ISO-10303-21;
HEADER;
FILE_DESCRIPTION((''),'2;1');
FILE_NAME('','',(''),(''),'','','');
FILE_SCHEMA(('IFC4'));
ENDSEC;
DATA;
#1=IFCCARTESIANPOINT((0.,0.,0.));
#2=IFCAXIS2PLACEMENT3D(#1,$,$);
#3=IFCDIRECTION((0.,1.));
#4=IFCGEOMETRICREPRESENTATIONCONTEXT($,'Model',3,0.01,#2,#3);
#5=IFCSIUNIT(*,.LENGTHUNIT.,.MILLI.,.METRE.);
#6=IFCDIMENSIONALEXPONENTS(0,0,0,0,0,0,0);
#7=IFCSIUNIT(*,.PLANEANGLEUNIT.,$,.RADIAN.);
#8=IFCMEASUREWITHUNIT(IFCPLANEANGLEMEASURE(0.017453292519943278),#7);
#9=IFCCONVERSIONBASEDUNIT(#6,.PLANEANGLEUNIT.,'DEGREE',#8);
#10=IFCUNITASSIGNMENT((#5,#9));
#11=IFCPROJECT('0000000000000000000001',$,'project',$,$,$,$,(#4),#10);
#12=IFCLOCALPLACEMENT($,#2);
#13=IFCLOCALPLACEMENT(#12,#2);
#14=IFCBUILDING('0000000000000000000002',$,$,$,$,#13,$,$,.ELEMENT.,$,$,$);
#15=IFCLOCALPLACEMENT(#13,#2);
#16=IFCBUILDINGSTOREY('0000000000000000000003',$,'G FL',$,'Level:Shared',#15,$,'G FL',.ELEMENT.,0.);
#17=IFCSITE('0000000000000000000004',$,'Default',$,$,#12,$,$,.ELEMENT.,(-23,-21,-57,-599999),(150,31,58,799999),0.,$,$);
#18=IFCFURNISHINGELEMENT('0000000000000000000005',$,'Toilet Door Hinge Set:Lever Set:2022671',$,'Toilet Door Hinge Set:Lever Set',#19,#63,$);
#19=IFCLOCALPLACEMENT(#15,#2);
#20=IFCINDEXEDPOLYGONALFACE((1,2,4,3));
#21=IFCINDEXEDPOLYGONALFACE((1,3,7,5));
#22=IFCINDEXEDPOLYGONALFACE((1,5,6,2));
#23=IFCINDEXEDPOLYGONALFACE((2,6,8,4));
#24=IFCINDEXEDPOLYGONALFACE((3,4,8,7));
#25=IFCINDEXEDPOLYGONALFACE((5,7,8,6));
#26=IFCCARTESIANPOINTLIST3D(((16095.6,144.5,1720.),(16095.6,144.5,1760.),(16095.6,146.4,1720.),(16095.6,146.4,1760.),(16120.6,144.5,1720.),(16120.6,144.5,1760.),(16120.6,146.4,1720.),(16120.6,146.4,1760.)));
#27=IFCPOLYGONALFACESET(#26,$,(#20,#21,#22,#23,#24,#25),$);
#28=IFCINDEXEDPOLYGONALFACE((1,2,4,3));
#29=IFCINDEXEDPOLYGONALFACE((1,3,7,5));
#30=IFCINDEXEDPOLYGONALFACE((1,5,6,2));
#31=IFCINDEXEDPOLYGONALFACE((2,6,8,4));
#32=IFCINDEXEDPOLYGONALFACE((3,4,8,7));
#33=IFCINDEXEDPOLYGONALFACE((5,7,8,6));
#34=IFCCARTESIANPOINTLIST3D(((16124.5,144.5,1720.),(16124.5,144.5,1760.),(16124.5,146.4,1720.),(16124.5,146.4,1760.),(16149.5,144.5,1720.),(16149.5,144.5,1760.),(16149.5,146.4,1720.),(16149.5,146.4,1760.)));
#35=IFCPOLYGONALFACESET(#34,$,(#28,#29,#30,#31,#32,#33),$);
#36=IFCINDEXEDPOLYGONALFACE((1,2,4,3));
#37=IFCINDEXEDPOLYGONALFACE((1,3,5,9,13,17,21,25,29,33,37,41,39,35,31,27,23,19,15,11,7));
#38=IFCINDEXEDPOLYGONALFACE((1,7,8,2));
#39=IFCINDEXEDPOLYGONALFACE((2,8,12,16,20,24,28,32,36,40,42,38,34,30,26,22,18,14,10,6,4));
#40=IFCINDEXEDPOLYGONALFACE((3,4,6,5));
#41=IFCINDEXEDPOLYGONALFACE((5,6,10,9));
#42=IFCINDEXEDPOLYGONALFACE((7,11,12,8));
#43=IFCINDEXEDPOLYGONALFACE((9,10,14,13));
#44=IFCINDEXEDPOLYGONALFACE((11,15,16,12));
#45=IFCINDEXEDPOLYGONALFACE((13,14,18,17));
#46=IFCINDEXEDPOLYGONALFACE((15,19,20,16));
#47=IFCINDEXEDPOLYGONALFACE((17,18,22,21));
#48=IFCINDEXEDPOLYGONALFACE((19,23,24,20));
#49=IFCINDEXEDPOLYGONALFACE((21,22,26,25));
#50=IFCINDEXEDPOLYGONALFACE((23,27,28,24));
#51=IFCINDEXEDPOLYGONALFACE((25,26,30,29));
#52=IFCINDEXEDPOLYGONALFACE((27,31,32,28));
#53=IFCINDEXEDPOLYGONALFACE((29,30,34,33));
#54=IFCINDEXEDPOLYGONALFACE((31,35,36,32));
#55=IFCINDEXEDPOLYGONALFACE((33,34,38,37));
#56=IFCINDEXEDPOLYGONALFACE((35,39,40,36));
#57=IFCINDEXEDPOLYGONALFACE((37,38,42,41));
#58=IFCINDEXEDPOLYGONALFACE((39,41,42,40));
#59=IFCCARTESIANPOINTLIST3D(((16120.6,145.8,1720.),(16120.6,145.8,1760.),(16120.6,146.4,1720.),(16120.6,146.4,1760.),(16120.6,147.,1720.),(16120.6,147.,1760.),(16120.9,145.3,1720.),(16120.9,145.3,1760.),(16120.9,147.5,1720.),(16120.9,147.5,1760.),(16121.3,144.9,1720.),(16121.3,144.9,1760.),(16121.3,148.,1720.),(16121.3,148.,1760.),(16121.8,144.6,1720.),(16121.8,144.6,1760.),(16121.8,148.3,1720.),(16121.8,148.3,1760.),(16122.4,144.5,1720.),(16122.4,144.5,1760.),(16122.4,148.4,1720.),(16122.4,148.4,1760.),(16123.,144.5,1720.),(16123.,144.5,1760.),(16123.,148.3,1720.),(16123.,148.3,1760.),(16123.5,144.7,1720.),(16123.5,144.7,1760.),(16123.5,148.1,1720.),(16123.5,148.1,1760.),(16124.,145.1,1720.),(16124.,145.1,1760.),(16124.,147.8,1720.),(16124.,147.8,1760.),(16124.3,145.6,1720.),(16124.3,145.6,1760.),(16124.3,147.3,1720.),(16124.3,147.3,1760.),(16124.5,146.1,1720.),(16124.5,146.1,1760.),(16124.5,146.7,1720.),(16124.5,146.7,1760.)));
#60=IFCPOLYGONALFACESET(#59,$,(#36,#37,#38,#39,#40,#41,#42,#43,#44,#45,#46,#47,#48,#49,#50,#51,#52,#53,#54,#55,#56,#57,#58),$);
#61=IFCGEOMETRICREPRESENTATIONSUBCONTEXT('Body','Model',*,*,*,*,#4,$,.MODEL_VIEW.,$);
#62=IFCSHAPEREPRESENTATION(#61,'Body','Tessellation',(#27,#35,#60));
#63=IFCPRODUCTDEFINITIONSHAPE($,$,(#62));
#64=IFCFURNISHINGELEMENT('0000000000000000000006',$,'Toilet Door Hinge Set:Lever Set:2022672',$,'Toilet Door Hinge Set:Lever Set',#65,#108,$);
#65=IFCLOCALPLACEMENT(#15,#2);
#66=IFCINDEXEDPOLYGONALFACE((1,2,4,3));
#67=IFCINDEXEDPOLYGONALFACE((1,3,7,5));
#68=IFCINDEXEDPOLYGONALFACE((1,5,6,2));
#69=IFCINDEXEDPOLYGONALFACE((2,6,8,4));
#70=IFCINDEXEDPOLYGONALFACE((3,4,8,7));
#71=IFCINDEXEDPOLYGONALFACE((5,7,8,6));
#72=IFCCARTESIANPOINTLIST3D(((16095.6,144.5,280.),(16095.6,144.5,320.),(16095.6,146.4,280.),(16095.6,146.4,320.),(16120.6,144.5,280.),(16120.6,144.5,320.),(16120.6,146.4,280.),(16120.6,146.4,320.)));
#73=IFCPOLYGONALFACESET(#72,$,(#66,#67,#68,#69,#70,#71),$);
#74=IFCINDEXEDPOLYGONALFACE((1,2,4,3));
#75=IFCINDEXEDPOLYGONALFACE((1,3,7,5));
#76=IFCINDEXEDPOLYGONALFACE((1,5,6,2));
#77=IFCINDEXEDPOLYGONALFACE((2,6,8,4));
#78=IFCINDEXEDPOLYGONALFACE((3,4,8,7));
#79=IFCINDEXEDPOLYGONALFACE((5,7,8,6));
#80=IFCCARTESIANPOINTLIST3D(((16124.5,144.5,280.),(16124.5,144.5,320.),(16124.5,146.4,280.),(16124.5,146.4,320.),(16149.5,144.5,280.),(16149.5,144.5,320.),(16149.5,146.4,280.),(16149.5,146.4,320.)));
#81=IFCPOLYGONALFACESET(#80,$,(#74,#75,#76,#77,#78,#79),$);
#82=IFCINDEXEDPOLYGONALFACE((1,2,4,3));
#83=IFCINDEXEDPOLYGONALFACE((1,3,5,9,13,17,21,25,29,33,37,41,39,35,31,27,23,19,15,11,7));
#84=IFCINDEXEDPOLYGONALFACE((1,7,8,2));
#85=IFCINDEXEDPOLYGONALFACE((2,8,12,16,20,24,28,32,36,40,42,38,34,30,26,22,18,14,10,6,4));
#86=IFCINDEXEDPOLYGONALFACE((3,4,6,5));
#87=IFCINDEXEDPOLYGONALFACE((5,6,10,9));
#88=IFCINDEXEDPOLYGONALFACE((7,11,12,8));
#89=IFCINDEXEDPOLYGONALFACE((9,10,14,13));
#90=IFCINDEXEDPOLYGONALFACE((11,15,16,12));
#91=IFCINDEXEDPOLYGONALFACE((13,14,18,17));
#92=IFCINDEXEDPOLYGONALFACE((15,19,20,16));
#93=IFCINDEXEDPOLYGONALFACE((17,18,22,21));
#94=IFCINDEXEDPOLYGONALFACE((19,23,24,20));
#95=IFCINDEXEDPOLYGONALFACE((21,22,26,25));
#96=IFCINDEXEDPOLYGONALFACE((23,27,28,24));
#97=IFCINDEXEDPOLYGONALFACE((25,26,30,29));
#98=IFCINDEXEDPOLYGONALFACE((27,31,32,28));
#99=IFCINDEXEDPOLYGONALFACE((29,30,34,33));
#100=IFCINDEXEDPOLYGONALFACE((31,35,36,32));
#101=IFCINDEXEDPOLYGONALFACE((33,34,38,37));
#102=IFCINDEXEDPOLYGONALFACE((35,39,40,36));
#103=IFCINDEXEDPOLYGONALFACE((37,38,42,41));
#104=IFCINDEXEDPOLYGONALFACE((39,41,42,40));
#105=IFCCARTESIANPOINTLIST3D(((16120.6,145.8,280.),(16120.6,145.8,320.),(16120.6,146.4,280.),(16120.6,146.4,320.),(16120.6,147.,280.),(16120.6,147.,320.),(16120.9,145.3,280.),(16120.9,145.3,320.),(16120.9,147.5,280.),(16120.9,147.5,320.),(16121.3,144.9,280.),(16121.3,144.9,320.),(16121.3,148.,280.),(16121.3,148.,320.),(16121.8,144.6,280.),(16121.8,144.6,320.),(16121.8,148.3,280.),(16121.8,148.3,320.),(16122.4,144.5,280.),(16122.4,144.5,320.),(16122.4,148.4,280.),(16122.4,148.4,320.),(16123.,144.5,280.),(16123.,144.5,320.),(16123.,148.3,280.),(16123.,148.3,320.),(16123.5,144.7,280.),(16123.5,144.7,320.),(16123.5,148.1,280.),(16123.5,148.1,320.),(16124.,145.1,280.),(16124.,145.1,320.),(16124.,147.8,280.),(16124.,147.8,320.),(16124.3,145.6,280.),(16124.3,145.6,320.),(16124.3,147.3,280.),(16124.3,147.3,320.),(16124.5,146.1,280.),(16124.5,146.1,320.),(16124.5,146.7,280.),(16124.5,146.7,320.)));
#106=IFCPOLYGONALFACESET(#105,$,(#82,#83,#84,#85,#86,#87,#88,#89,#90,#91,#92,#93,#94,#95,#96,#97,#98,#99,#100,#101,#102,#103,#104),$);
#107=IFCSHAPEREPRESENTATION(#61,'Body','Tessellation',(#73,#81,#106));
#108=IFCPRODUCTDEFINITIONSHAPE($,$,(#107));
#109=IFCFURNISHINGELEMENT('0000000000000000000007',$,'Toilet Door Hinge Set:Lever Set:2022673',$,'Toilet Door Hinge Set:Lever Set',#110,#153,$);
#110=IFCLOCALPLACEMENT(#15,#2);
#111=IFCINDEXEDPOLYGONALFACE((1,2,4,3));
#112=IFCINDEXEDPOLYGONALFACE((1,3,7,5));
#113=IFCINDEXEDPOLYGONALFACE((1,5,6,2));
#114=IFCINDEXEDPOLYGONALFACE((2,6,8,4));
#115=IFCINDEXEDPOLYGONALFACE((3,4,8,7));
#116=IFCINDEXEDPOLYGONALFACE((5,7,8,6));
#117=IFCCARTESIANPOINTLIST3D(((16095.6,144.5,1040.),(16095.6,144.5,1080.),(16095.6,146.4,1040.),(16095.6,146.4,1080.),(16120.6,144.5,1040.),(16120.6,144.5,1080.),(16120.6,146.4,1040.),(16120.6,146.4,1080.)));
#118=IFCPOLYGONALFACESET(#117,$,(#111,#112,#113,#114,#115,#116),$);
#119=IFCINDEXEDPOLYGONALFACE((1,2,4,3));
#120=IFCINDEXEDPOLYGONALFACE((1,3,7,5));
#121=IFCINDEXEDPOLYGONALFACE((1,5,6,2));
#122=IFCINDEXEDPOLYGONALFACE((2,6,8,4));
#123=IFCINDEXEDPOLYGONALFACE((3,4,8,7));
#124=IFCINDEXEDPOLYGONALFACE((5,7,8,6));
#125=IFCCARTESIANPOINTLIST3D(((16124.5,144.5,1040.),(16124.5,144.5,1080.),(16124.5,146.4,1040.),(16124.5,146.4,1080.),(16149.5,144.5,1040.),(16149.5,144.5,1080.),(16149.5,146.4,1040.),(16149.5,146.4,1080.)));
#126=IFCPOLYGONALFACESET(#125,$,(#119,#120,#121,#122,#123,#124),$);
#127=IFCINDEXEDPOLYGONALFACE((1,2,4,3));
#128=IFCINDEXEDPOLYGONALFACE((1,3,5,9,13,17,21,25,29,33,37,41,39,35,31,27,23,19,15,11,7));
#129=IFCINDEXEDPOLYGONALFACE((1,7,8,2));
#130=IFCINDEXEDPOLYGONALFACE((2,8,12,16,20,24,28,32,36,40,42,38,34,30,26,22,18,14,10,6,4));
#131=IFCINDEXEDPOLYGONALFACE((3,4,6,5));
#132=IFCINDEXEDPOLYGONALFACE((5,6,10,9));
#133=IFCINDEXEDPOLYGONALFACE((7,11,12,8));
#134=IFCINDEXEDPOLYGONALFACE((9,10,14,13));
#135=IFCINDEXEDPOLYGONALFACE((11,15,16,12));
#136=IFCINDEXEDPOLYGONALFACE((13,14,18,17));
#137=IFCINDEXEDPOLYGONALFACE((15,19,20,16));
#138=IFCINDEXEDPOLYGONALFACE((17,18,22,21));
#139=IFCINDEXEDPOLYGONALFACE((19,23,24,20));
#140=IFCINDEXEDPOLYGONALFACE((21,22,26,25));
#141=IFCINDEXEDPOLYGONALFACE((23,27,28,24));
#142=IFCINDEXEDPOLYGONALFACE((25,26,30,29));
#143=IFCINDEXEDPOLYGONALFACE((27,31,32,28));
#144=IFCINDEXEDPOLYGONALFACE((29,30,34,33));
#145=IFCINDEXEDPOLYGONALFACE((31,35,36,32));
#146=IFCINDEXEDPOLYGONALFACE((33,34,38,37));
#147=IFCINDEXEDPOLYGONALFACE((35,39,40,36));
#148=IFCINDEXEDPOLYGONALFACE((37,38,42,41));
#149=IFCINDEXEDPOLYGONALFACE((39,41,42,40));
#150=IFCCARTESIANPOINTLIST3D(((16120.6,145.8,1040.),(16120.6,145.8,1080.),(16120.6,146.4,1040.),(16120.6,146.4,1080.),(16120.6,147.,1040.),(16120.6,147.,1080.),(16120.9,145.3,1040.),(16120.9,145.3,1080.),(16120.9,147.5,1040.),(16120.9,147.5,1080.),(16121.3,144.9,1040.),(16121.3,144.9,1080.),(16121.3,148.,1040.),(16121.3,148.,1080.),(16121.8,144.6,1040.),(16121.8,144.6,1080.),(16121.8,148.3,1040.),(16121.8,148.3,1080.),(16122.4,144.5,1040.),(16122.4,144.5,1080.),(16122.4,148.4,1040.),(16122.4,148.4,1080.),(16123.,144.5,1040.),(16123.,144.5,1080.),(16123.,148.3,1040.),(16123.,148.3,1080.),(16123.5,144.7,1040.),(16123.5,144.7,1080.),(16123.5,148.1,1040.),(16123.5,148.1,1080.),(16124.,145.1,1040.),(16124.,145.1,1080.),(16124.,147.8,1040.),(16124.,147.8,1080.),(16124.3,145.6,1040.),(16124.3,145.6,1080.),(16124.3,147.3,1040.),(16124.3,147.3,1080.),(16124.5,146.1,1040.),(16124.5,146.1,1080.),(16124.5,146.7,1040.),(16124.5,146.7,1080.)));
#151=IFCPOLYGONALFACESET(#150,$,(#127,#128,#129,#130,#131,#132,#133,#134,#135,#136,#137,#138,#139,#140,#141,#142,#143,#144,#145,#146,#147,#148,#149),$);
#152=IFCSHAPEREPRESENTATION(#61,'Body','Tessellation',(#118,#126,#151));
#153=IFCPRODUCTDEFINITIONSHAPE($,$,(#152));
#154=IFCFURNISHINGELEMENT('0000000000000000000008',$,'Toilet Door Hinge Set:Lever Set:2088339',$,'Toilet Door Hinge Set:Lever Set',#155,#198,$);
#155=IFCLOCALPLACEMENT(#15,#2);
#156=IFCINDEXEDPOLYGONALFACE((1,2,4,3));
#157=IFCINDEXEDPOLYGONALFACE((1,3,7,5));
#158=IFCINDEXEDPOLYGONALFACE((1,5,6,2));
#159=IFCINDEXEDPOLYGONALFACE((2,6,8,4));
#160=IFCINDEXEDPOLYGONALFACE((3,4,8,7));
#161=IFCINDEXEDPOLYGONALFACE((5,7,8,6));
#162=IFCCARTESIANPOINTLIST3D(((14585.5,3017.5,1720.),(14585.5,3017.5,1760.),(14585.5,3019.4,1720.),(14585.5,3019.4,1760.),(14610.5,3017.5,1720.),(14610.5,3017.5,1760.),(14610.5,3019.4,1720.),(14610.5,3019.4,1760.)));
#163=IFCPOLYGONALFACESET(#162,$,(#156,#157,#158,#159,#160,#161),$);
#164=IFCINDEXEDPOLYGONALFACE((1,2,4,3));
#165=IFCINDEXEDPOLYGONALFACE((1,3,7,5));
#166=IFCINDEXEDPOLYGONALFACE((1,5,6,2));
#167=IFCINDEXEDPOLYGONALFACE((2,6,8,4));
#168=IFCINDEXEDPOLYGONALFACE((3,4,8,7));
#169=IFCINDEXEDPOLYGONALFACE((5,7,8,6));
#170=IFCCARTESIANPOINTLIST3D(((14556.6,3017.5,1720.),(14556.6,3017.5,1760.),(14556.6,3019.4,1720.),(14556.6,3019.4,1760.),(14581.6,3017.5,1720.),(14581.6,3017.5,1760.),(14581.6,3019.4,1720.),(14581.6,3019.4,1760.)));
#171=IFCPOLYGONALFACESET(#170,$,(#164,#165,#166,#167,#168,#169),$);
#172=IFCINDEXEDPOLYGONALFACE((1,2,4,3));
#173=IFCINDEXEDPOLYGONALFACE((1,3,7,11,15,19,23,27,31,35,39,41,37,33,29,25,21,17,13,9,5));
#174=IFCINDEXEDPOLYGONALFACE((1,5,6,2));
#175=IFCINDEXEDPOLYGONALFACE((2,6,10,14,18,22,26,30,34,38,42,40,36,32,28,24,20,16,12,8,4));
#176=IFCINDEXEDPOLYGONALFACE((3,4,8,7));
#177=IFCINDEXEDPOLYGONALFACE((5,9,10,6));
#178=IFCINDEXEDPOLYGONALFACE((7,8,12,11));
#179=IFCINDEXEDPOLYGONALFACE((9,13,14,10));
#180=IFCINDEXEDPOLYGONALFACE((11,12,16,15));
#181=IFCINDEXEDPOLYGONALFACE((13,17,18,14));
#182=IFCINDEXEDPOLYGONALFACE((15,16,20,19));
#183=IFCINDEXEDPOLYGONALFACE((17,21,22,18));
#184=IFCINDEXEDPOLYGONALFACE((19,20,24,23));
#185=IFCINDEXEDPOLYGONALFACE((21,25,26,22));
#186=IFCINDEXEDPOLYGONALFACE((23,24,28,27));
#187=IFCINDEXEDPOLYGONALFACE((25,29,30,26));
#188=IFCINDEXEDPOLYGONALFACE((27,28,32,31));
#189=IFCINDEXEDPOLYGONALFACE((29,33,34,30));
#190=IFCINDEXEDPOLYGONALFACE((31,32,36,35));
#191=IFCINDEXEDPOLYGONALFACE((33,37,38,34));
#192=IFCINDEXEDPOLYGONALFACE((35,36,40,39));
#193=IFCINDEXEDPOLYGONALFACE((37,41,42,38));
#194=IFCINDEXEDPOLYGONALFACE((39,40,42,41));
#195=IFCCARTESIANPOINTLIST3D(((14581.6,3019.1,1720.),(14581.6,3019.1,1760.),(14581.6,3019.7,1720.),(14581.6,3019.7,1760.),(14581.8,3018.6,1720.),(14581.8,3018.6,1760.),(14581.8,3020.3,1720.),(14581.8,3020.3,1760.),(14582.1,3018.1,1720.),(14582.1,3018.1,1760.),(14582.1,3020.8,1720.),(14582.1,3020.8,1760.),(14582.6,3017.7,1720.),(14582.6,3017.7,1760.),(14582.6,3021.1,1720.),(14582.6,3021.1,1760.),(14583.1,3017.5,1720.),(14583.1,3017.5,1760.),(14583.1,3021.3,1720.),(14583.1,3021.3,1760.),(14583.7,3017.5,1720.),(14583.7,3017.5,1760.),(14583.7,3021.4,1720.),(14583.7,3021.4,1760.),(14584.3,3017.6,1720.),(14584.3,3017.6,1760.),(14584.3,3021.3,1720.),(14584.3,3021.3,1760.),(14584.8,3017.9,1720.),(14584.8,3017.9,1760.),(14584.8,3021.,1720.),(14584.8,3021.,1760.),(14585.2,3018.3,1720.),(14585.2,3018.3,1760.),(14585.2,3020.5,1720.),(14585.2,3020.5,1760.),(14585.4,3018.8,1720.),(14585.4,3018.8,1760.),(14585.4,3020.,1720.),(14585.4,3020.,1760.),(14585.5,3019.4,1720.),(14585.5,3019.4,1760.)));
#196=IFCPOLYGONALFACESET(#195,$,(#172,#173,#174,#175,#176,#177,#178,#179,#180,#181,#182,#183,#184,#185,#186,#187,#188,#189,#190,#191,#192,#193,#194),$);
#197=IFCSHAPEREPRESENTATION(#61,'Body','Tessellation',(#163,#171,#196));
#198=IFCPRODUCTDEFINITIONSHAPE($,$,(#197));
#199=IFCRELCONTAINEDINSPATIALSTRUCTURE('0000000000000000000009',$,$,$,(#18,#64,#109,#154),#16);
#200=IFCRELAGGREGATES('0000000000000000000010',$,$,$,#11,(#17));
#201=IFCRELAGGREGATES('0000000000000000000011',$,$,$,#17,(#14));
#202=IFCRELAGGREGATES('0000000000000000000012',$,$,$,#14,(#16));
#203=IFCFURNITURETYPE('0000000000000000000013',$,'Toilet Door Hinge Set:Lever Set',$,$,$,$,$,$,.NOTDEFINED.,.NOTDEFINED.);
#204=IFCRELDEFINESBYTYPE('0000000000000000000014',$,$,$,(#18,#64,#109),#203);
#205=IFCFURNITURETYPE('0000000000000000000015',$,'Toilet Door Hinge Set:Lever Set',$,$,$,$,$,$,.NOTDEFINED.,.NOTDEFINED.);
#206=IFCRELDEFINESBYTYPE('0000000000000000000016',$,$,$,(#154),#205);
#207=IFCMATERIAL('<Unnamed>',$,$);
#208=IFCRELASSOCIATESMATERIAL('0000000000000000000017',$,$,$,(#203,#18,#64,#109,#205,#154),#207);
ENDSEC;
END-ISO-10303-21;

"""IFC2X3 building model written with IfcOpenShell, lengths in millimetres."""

from ifc_helpers import new_model, entity, si_unit, converted_unit, direction, frame, frame_2d, origin, place, context, subcontext, project, spatial, rectangle, circle, extrude, source, transform, mapped, material, type_object, type_shapes, element, save


model = new_model("IFC2X3")

# Units and contexts
model_context = context("Model", 3, precision=0.01, world=origin(), true_north=direction((0.0, 1.0)))
body_context = subcontext(model_context, "Body", "Model", "MODEL_VIEW")
ifc_project = project(units=[si_unit("LENGTHUNIT", "METRE", prefix="MILLI"), converted_unit("PLANEANGLEUNIT", "DEGREE", entity("IfcPlaneAngleMeasure", 0.017453292519943278), si_unit("PLANEANGLEUNIT", "RADIAN"), dimensions=[0, 0, 0, 0, 0, 0, 0])], contexts=[model_context])

# Site, building, storey
site_placement = place(None, origin())
site = spatial("IfcSite", under=ifc_project, at=site_placement, Name="Default", CompositionType="ELEMENT", RefLatitude=(-23, -21, -57, -599999), RefLongitude=(150, 31, 58, 799999), RefElevation=0.0)
building_placement = place(site_placement, origin())
building = spatial("IfcBuilding", under=site, at=building_placement, CompositionType="ELEMENT")
storey_placement = place(building_placement, origin())
storey = spatial("IfcBuildingStorey", under=building, at=storey_placement, Name="G FL", ObjectType="Level:Shared", LongName="G FL", CompositionType="ELEMENT", Elevation=0.0)

# Furnishing elements
ifc_material_1 = material(Name="<Unnamed>")
furniture_type_1 = type_object("IfcFurnitureType", Name="Toilet Door Hinge Set:Lever Set", AssemblyPlace="NOTDEFINED", material=ifc_material_1)
shared_shape_1 = source(origin(), body_context, "Body", "SweptSolid", [
    extrude(rectangle(XDim=2.0, YDim=25.0, at=frame_2d((0.0, 0.0), x_axis=(1.0, 0.0))), frame((14.5, 1.0, -20.0), z_axis=(0.0, 0.0, 1.0), x_axis=(0.0, 1.0, 0.0)), (0.0, 0.0, 1.0), 40.0),
    extrude(rectangle(XDim=25.0, YDim=2.0, at=frame_2d((0.0, 0.0), x_axis=(1.0, 0.0))), frame((-14.5, 1.0, -20.0)), (0.0, 0.0, 1.0), 40.0),
    extrude(circle(Radius=2.0, at=frame_2d((0.0, 0.0), x_axis=(1.0, 0.0))), frame((0.0, 0.0, -20.0)), (0.0, 0.0, 1.0), 40.0),
])
type_shapes(furniture_type_1, [shared_shape_1])
for number, where, z_axis, x_axis, name in (
    (1, (16122.5, 146.4, 1740.0), (0.0, 0.0, 1.0), (-1.0, 0.0, 0.0), "Toilet Door Hinge Set:Lever Set:2022671"),
    (2, (16122.5, 146.4, 300.0), (0.0, 0.0, 1.0), (-1.0, 0.0, 0.0), "Toilet Door Hinge Set:Lever Set:2022672"),
    (3, (16122.5, 146.4, 1060.0), (0.0, 0.0, 1.0), (-1.0, 0.0, 0.0), "Toilet Door Hinge Set:Lever Set:2022673"),
):
    element("IfcFurnishingElement", number, at=place(storey_placement, frame(where, z_axis=z_axis, x_axis=x_axis)), inside=storey, type_object=furniture_type_1, material=ifc_material_1, Name=name, ObjectType="Toilet Door Hinge Set:Lever Set", context=body_context, shape_type="MappedRepresentation", body=[
        mapped(shared_shape_1, transform((0.0, 0.0, 0.0), scale=1.0)),
    ])
furniture_type_2 = type_object("IfcFurnitureType", Name="Toilet Door Hinge Set:Lever Set", AssemblyPlace="NOTDEFINED", material=ifc_material_1)
shared_shape_2 = source(origin(), body_context, "Body", "SweptSolid", [
    extrude(rectangle(XDim=25.0, YDim=2.0, at=frame_2d((0.0, 0.0), x_axis=(1.0, 0.0))), frame((14.5, -1.0, -20.0), z_axis=(0.0, 0.0, 1.0), x_axis=(-1.0, 0.0, 0.0)), (0.0, 0.0, 1.0), 40.0),
    extrude(rectangle(XDim=2.0, YDim=25.0, at=frame_2d((0.0, 0.0), x_axis=(1.0, 0.0))), frame((-14.5, -1.0, -20.0), z_axis=(0.0, 0.0, 1.0), x_axis=(0.0, -1.0, 0.0)), (0.0, 0.0, 1.0), 40.0),
    extrude(circle(Radius=2.0, at=frame_2d((0.0, 0.0), x_axis=(1.0, 0.0))), frame((0.0, 0.0, -20.0)), (0.0, 0.0, 1.0), 40.0),
])
type_shapes(furniture_type_2, [shared_shape_2])
for number, where, name in (
    (4, (14583.5, 3019.4, 1740.0), "Toilet Door Hinge Set:Lever Set:2088339"),
):
    element("IfcFurnishingElement", number, at=place(storey_placement, frame(where)), inside=storey, type_object=furniture_type_2, material=ifc_material_1, Name=name, ObjectType="Toilet Door Hinge Set:Lever Set", context=body_context, shape_type="MappedRepresentation", body=[
        mapped(shared_shape_2, transform((0.0, 0.0, 0.0), scale=1.0)),
    ])

save(model, "model.ifc")
